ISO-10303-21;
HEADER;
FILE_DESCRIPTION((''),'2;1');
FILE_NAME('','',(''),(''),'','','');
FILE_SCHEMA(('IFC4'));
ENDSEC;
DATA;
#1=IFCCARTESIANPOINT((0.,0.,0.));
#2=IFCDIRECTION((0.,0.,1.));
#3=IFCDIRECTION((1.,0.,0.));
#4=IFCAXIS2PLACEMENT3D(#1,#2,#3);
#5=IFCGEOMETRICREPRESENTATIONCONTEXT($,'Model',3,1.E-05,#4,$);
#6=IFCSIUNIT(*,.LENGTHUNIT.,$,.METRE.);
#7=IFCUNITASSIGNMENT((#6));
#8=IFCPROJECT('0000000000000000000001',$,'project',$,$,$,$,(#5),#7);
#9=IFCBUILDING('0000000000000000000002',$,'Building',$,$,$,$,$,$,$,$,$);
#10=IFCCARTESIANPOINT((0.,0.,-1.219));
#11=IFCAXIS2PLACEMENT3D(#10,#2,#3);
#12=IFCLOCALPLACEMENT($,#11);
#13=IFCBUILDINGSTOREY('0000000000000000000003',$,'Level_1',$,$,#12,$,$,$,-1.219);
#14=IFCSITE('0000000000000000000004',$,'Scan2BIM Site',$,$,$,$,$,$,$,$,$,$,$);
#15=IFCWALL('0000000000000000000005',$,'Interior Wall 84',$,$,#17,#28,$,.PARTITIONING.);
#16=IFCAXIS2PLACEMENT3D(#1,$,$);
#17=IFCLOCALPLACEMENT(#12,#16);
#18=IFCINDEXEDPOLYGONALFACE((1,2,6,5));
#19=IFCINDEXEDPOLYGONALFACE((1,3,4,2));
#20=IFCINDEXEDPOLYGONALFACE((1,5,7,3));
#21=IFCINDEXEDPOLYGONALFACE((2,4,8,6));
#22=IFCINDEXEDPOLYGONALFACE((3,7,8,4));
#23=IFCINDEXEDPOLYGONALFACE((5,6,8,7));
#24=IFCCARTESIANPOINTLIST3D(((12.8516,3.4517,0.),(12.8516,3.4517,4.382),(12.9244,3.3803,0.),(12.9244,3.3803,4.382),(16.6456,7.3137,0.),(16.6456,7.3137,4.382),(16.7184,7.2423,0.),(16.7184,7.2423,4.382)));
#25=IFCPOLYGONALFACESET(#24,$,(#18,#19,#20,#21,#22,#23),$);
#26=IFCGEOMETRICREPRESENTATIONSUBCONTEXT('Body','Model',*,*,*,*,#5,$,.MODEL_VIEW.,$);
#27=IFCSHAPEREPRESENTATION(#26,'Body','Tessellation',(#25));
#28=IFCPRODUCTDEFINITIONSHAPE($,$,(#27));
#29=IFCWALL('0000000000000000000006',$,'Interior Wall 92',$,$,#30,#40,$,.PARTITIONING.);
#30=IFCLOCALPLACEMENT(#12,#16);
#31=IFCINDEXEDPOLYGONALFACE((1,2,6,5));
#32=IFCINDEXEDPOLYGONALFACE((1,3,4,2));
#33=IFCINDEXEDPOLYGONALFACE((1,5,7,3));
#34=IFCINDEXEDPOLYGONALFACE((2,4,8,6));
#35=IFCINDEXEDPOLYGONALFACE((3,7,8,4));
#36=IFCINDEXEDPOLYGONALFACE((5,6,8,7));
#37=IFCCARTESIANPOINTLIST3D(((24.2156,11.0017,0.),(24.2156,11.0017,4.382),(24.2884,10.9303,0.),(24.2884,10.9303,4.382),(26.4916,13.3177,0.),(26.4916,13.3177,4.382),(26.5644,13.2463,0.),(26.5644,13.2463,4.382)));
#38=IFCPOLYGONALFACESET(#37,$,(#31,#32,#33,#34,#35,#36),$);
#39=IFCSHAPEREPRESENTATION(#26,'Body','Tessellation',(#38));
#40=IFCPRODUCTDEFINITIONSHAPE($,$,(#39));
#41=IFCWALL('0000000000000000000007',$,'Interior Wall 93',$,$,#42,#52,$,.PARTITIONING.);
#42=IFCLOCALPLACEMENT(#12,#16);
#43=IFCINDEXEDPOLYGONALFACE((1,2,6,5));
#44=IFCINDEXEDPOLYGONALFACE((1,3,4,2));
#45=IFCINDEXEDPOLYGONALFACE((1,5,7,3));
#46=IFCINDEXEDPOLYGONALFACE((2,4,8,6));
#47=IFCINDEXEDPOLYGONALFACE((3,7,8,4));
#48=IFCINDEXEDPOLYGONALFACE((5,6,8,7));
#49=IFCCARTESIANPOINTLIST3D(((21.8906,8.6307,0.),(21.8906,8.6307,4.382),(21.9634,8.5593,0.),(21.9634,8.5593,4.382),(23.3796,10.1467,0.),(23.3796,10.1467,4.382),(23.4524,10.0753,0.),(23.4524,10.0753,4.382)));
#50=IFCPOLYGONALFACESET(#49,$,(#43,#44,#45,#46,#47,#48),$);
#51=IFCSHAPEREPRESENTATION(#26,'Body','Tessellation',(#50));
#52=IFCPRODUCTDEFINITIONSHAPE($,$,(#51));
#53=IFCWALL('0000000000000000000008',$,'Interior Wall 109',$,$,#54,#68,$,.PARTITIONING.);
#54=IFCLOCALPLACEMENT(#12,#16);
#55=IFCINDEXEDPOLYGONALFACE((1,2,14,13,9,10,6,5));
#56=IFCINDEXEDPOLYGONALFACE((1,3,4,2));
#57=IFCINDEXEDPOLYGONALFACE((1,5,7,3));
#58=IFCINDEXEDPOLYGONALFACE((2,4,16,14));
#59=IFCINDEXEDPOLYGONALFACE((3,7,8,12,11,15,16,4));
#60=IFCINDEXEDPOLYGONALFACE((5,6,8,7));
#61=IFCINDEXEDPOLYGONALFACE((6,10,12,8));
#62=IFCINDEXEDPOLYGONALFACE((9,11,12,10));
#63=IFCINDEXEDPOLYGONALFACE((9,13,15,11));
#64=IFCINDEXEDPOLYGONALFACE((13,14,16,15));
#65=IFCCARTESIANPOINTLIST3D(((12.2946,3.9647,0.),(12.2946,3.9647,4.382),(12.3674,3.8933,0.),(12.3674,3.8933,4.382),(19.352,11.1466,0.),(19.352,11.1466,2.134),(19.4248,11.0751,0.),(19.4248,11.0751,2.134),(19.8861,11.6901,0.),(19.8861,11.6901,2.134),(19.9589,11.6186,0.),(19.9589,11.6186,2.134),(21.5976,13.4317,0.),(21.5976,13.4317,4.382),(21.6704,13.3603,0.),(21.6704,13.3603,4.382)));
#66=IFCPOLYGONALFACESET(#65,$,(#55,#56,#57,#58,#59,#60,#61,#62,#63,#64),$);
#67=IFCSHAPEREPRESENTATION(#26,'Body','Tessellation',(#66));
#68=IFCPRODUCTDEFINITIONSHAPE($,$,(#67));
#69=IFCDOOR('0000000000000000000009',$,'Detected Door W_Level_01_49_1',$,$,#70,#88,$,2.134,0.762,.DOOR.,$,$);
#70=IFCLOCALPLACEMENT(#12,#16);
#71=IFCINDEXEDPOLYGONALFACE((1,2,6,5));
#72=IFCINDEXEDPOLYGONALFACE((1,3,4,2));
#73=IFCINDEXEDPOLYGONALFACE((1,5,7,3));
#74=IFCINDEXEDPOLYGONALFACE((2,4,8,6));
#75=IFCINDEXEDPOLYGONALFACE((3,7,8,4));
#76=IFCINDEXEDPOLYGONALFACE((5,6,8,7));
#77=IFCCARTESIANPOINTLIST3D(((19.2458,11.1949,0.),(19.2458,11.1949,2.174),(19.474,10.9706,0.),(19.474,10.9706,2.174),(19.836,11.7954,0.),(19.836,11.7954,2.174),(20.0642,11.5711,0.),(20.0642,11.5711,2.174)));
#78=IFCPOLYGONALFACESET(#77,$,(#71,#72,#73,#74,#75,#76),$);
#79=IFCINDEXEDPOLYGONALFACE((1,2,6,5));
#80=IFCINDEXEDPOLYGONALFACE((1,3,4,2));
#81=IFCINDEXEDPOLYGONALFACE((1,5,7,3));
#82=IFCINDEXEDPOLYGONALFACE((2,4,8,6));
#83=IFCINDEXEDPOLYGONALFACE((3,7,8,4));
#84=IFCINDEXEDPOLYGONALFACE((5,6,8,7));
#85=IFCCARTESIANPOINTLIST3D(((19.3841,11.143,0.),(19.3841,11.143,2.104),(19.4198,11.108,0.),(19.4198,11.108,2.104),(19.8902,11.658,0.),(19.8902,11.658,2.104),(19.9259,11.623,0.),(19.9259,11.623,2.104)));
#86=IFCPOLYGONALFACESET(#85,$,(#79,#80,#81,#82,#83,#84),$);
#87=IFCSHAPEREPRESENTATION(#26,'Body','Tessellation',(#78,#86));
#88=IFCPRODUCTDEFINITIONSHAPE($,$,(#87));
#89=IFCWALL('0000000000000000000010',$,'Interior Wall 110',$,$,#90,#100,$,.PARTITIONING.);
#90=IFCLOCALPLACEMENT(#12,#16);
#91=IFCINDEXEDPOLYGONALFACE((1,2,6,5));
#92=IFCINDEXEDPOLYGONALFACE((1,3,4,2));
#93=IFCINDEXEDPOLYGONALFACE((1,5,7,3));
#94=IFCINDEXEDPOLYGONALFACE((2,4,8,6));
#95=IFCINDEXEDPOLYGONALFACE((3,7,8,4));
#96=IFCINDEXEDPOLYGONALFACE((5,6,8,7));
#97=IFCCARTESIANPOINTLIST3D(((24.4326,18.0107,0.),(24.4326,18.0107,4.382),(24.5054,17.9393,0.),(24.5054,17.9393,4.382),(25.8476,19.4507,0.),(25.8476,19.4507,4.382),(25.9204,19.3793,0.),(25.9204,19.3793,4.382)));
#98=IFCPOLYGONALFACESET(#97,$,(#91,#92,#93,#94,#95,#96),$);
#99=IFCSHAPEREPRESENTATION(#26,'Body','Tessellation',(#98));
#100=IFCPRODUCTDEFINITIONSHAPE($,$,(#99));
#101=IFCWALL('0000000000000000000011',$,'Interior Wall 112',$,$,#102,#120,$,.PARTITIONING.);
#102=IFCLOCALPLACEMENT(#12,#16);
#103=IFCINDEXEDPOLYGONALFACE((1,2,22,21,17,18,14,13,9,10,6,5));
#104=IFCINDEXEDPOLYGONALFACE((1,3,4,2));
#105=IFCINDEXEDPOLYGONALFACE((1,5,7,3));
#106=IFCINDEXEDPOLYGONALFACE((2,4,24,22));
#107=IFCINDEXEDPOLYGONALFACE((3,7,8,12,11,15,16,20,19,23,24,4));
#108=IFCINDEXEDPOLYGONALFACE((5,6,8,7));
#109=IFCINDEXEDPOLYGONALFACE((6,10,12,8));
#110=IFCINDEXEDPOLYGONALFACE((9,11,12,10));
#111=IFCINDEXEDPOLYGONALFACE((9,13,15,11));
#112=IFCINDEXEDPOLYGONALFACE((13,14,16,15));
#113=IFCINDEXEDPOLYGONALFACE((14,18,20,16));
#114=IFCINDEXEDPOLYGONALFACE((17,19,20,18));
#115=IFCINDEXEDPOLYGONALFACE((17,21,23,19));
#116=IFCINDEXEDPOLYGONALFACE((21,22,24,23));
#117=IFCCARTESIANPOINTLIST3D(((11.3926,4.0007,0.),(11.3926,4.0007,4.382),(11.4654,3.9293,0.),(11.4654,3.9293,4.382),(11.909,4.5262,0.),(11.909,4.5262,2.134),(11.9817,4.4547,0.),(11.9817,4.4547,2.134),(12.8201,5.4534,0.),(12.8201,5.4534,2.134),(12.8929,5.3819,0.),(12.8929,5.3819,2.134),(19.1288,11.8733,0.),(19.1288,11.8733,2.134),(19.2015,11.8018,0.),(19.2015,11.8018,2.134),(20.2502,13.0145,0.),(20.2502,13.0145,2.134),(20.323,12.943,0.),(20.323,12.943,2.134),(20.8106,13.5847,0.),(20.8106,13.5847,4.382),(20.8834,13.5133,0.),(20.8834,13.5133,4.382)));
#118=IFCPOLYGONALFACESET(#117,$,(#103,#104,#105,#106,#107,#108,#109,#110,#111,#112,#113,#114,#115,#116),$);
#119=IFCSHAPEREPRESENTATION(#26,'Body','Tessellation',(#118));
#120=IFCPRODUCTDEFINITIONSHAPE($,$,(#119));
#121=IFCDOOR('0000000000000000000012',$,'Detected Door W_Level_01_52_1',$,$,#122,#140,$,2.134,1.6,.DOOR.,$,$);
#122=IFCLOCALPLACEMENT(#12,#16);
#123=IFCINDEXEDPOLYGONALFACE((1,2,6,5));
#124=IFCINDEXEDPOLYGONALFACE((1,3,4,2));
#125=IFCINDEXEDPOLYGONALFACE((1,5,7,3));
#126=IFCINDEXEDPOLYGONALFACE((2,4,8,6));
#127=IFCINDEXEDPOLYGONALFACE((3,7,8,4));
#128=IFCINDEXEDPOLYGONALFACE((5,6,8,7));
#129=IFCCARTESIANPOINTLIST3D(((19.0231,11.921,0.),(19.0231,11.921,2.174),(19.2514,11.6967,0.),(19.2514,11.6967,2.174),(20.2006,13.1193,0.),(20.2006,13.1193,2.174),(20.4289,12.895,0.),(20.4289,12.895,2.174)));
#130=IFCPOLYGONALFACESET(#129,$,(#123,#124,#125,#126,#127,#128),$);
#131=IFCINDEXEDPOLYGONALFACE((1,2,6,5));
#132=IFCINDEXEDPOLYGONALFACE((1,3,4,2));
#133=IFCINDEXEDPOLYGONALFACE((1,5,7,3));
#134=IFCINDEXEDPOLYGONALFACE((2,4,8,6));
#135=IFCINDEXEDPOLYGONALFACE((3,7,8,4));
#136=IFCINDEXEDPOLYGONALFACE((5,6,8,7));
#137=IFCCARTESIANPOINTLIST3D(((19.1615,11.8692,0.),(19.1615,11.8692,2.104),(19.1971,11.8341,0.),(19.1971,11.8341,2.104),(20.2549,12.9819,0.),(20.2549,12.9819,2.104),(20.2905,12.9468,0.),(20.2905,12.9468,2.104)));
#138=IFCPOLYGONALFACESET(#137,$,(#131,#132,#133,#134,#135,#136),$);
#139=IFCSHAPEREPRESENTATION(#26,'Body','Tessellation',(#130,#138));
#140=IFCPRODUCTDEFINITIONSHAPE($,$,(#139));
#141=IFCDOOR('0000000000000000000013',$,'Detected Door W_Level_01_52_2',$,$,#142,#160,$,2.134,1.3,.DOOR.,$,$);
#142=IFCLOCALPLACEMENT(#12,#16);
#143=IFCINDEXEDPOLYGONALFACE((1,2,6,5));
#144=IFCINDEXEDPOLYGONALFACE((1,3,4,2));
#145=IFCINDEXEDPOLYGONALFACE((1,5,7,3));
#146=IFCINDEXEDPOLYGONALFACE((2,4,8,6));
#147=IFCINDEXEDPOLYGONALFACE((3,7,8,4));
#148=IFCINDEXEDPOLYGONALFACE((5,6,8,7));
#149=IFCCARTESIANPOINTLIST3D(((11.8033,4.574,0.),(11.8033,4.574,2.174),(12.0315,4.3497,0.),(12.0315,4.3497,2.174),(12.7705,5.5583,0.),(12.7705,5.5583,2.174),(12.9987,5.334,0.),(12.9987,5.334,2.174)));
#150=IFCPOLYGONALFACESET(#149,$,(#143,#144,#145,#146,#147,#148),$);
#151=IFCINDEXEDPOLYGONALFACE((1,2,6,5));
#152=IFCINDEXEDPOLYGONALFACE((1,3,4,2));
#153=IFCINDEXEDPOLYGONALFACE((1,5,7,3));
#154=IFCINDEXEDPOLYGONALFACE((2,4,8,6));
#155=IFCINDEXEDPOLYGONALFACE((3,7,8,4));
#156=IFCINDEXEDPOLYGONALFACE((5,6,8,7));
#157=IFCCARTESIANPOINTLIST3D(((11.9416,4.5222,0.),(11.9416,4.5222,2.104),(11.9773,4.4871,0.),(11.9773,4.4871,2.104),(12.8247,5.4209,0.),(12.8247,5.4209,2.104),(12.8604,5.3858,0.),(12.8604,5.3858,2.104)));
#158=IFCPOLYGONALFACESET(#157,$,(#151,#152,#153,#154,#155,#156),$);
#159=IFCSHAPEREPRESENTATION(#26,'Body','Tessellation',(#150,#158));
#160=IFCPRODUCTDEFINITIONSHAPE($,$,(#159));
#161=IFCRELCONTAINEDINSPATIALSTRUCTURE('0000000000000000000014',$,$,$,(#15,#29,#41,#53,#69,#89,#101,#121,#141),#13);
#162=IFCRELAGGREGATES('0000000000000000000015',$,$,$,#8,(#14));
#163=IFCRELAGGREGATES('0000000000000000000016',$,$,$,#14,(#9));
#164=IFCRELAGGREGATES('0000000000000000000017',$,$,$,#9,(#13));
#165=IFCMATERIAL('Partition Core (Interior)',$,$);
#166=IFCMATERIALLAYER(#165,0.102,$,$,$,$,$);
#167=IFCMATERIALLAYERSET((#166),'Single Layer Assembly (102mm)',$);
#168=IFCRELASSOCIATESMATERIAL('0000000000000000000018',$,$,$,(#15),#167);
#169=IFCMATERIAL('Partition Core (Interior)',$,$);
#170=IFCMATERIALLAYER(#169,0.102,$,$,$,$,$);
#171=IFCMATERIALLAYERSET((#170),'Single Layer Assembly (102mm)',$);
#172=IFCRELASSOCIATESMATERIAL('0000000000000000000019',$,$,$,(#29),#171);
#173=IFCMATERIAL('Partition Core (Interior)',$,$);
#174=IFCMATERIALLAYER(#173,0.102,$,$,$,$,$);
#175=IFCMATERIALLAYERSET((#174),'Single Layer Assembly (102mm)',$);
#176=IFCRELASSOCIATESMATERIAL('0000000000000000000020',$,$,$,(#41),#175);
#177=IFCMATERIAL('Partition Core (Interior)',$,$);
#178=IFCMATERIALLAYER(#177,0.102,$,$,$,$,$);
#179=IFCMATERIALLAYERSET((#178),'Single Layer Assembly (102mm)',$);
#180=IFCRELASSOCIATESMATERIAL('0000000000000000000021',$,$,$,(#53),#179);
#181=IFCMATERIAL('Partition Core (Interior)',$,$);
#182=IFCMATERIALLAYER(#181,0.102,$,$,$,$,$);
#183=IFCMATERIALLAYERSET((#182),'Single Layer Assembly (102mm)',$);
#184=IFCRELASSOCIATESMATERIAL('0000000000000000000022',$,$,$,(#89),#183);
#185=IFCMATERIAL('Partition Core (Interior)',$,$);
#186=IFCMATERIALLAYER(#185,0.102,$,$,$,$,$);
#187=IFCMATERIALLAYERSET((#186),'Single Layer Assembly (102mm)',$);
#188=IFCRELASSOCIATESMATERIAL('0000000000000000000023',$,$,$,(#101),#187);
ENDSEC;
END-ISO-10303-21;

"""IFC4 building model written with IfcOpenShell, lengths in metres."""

from ifc_helpers import new_model, si_unit, frame, origin, origin_with_axes, place, context, subcontext, project, spatial, rectangle, extrude, material, layer, layer_set, element, fill, save


model = new_model("IFC4")

# Units and contexts
model_context = context("Model", 3, precision=1e-05, world=origin_with_axes())
body_context = subcontext(model_context, "Body", "Model", "MODEL_VIEW")
ifc_project = project(units=[si_unit("LENGTHUNIT", "METRE")], contexts=[model_context])

# Site, building, storey
site = spatial("IfcSite", under=ifc_project, Name="Scan2BIM Site")
building = spatial("IfcBuilding", under=site, Name="Building")
storey_placement = place(None, frame((0.0, 0.0, -1.219), z_axis=(0.0, 0.0, 1.0), x_axis=(1.0, 0.0, 0.0)))
storey = spatial("IfcBuildingStorey", under=building, at=storey_placement, Name="Level_1", Elevation=-1.219)

# Walls
ifc_material_1 = material(Name="Partition Core (Interior)")
ifc_layer_1 = layer(ifc_material_1, 0.102)
ifc_layer_set_1 = layer_set([ifc_layer_1], Name="Single Layer Assembly (102mm)")
wall_1_placement = place(storey_placement, frame((14.785, 5.347, 0.0), z_axis=(0.0, 0.0, 1.0), x_axis=(-0.700799, -0.713359, 0.0)))
element("IfcWall", 1, at=wall_1_placement, inside=storey, material=ifc_layer_set_1, Name="Interior Wall 84", PredefinedType="PARTITIONING", context=body_context, shape_type="SweptSolid", body=[
    extrude(rectangle(XDim=5.4138, YDim=0.102), origin(), (0.0, 0.0, 1.0), 4.382),
])
ifc_material_2 = material(Name="Partition Core (Interior)")
ifc_layer_2 = layer(ifc_material_2, 0.102)
ifc_layer_set_2 = layer_set([ifc_layer_2], Name="Single Layer Assembly (102mm)")
wall_2_placement = place(storey_placement, frame((25.39, 12.124, 0.0), z_axis=(0.0, 0.0, 1.0), x_axis=(-0.700921, -0.713239, 0.0)))
element("IfcWall", 2, at=wall_2_placement, inside=storey, material=ifc_layer_set_2, Name="Interior Wall 92", PredefinedType="PARTITIONING", context=body_context, shape_type="SweptSolid", body=[
    extrude(rectangle(XDim=3.2472, YDim=0.102), origin(), (0.0, 0.0, 1.0), 4.382),
])
ifc_material_3 = material(Name="Partition Core (Interior)")
ifc_layer_3 = layer(ifc_material_3, 0.102)
ifc_layer_set_3 = layer_set([ifc_layer_3], Name="Single Layer Assembly (102mm)")
wall_3_placement = place(storey_placement, frame((22.6715, 9.353, 0.0), z_axis=(0.0, 0.0, 1.0), x_axis=(-0.700725, -0.713431, 0.0)))
element("IfcWall", 3, at=wall_3_placement, inside=storey, material=ifc_layer_set_3, Name="Interior Wall 93", PredefinedType="PARTITIONING", context=body_context, shape_type="SweptSolid", body=[
    extrude(rectangle(XDim=2.1249, YDim=0.102), origin(), (0.0, 0.0, 1.0), 4.382),
])

# Wall, opening, door
ifc_material_4 = material(Name="Partition Core (Interior)")
ifc_layer_4 = layer(ifc_material_4, 0.102)
ifc_layer_set_4 = layer_set([ifc_layer_4], Name="Single Layer Assembly (102mm)")
wall_4_placement = place(storey_placement, frame((16.9825, 8.6625, 0.0), z_axis=(0.0, 0.0, 1.0), x_axis=(0.700902, 0.713258, 0.0)))
wall_4 = element("IfcWall", 4, at=wall_4_placement, inside=storey, material=ifc_layer_set_4, Name="Interior Wall 109", PredefinedType="PARTITIONING", context=body_context, shape_type="SweptSolid", body=[
    extrude(rectangle(XDim=13.2729, YDim=0.102), origin(), (0.0, 0.0, 1.0), 4.382),
])
opening_1_placement = place(None, frame((19.655, 11.383, -1.219), z_axis=(0.0, 0.0, 1.0), x_axis=(0.700902, 0.713258, 0.0)))
opening_1 = element("IfcOpeningElement", 5, at=opening_1_placement, cuts=wall_4, PredefinedType="OPENING", context=body_context, shape_type="SweptSolid", body=[
    extrude(rectangle(XDim=0.762, YDim=0.202), origin(), (0.0, 0.0, 1.0), 2.134),
])
door_1_placement = place(opening_1_placement, frame((0.0, 0.0, 0.0), z_axis=(0.0, 0.0, 1.0), x_axis=(1.0, 0.0, 0.0)))
door_1 = element("IfcDoor", 6, at=door_1_placement, inside=storey, Name="Detected Door W_Level_01_49_1", OverallHeight=2.134, OverallWidth=0.762, PredefinedType="DOOR", context=body_context, shape_type="SweptSolid", body=[
    extrude(rectangle(XDim=0.842, YDim=0.32), origin(), (0.0, 0.0, 1.0), 2.174),
    extrude(rectangle(XDim=0.722, YDim=0.05), origin(), (0.0, 0.0, 1.0), 2.104),
])
fill(opening_1, door_1)

# Wall
ifc_material_5 = material(Name="Partition Core (Interior)")
ifc_layer_5 = layer(ifc_material_5, 0.102)
ifc_layer_set_5 = layer_set([ifc_layer_5], Name="Single Layer Assembly (102mm)")
wall_5_placement = place(storey_placement, frame((25.1765, 18.695, 0.0), z_axis=(0.0, 0.0, 1.0), x_axis=(0.700888, 0.713271, 0.0)))
element("IfcWall", 7, at=wall_5_placement, inside=storey, material=ifc_layer_set_5, Name="Interior Wall 110", PredefinedType="PARTITIONING", context=body_context, shape_type="SweptSolid", body=[
    extrude(rectangle(XDim=2.0189, YDim=0.102), origin(), (0.0, 0.0, 1.0), 4.382),
])

# Wall, openings, doors
ifc_material_6 = material(Name="Partition Core (Interior)")
ifc_layer_6 = layer(ifc_material_6, 0.102)
ifc_layer_set_6 = layer_set([ifc_layer_6], Name="Single Layer Assembly (102mm)")
wall_6_placement = place(storey_placement, frame((16.138, 8.757, 0.0), z_axis=(0.0, 0.0, 1.0), x_axis=(-0.700903, -0.713257, 0.0)))
wall_6 = element("IfcWall", 8, at=wall_6_placement, inside=storey, material=ifc_layer_set_6, Name="Interior Wall 112", PredefinedType="PARTITIONING", context=body_context, shape_type="SweptSolid", body=[
    extrude(rectangle(XDim=13.437, YDim=0.102), origin(), (0.0, 0.0, 1.0), 4.382),
])
opening_2_placement = place(None, frame((19.726, 12.408, -1.219), z_axis=(0.0, 0.0, 1.0), x_axis=(-0.700903, -0.713257, 0.0)))
opening_2 = element("IfcOpeningElement", 9, at=opening_2_placement, cuts=wall_6, PredefinedType="OPENING", context=body_context, shape_type="SweptSolid", body=[
    extrude(rectangle(XDim=1.6, YDim=0.202), origin(), (0.0, 0.0, 1.0), 2.134),
])
opening_3_placement = place(None, frame((12.401, 4.954, -1.219), z_axis=(0.0, 0.0, 1.0), x_axis=(-0.700903, -0.713257, 0.0)))
opening_3 = element("IfcOpeningElement", 10, at=opening_3_placement, cuts=wall_6, PredefinedType="OPENING", context=body_context, shape_type="SweptSolid", body=[
    extrude(rectangle(XDim=1.3, YDim=0.202), origin(), (0.0, 0.0, 1.0), 2.134),
])
door_2_placement = place(opening_2_placement, frame((0.0, 0.0, 0.0), z_axis=(0.0, 0.0, 1.0), x_axis=(1.0, 0.0, 0.0)))
door_2 = element("IfcDoor", 11, at=door_2_placement, inside=storey, Name="Detected Door W_Level_01_52_1", OverallHeight=2.134, OverallWidth=1.6, PredefinedType="DOOR", context=body_context, shape_type="SweptSolid", body=[
    extrude(rectangle(XDim=1.68, YDim=0.32), origin(), (0.0, 0.0, 1.0), 2.174),
    extrude(rectangle(XDim=1.56, YDim=0.05), origin(), (0.0, 0.0, 1.0), 2.104),
])
fill(opening_2, door_2)
door_3_placement = place(opening_3_placement, frame((0.0, 0.0, 0.0), z_axis=(0.0, 0.0, 1.0), x_axis=(1.0, 0.0, 0.0)))
door_3 = element("IfcDoor", 12, at=door_3_placement, inside=storey, Name="Detected Door W_Level_01_52_2", OverallHeight=2.134, OverallWidth=1.3, PredefinedType="DOOR", context=body_context, shape_type="SweptSolid", body=[
    extrude(rectangle(XDim=1.38, YDim=0.32), origin(), (0.0, 0.0, 1.0), 2.174),
    extrude(rectangle(XDim=1.26, YDim=0.05), origin(), (0.0, 0.0, 1.0), 2.104),
])
fill(opening_3, door_3)

save(model, "model.ifc")
